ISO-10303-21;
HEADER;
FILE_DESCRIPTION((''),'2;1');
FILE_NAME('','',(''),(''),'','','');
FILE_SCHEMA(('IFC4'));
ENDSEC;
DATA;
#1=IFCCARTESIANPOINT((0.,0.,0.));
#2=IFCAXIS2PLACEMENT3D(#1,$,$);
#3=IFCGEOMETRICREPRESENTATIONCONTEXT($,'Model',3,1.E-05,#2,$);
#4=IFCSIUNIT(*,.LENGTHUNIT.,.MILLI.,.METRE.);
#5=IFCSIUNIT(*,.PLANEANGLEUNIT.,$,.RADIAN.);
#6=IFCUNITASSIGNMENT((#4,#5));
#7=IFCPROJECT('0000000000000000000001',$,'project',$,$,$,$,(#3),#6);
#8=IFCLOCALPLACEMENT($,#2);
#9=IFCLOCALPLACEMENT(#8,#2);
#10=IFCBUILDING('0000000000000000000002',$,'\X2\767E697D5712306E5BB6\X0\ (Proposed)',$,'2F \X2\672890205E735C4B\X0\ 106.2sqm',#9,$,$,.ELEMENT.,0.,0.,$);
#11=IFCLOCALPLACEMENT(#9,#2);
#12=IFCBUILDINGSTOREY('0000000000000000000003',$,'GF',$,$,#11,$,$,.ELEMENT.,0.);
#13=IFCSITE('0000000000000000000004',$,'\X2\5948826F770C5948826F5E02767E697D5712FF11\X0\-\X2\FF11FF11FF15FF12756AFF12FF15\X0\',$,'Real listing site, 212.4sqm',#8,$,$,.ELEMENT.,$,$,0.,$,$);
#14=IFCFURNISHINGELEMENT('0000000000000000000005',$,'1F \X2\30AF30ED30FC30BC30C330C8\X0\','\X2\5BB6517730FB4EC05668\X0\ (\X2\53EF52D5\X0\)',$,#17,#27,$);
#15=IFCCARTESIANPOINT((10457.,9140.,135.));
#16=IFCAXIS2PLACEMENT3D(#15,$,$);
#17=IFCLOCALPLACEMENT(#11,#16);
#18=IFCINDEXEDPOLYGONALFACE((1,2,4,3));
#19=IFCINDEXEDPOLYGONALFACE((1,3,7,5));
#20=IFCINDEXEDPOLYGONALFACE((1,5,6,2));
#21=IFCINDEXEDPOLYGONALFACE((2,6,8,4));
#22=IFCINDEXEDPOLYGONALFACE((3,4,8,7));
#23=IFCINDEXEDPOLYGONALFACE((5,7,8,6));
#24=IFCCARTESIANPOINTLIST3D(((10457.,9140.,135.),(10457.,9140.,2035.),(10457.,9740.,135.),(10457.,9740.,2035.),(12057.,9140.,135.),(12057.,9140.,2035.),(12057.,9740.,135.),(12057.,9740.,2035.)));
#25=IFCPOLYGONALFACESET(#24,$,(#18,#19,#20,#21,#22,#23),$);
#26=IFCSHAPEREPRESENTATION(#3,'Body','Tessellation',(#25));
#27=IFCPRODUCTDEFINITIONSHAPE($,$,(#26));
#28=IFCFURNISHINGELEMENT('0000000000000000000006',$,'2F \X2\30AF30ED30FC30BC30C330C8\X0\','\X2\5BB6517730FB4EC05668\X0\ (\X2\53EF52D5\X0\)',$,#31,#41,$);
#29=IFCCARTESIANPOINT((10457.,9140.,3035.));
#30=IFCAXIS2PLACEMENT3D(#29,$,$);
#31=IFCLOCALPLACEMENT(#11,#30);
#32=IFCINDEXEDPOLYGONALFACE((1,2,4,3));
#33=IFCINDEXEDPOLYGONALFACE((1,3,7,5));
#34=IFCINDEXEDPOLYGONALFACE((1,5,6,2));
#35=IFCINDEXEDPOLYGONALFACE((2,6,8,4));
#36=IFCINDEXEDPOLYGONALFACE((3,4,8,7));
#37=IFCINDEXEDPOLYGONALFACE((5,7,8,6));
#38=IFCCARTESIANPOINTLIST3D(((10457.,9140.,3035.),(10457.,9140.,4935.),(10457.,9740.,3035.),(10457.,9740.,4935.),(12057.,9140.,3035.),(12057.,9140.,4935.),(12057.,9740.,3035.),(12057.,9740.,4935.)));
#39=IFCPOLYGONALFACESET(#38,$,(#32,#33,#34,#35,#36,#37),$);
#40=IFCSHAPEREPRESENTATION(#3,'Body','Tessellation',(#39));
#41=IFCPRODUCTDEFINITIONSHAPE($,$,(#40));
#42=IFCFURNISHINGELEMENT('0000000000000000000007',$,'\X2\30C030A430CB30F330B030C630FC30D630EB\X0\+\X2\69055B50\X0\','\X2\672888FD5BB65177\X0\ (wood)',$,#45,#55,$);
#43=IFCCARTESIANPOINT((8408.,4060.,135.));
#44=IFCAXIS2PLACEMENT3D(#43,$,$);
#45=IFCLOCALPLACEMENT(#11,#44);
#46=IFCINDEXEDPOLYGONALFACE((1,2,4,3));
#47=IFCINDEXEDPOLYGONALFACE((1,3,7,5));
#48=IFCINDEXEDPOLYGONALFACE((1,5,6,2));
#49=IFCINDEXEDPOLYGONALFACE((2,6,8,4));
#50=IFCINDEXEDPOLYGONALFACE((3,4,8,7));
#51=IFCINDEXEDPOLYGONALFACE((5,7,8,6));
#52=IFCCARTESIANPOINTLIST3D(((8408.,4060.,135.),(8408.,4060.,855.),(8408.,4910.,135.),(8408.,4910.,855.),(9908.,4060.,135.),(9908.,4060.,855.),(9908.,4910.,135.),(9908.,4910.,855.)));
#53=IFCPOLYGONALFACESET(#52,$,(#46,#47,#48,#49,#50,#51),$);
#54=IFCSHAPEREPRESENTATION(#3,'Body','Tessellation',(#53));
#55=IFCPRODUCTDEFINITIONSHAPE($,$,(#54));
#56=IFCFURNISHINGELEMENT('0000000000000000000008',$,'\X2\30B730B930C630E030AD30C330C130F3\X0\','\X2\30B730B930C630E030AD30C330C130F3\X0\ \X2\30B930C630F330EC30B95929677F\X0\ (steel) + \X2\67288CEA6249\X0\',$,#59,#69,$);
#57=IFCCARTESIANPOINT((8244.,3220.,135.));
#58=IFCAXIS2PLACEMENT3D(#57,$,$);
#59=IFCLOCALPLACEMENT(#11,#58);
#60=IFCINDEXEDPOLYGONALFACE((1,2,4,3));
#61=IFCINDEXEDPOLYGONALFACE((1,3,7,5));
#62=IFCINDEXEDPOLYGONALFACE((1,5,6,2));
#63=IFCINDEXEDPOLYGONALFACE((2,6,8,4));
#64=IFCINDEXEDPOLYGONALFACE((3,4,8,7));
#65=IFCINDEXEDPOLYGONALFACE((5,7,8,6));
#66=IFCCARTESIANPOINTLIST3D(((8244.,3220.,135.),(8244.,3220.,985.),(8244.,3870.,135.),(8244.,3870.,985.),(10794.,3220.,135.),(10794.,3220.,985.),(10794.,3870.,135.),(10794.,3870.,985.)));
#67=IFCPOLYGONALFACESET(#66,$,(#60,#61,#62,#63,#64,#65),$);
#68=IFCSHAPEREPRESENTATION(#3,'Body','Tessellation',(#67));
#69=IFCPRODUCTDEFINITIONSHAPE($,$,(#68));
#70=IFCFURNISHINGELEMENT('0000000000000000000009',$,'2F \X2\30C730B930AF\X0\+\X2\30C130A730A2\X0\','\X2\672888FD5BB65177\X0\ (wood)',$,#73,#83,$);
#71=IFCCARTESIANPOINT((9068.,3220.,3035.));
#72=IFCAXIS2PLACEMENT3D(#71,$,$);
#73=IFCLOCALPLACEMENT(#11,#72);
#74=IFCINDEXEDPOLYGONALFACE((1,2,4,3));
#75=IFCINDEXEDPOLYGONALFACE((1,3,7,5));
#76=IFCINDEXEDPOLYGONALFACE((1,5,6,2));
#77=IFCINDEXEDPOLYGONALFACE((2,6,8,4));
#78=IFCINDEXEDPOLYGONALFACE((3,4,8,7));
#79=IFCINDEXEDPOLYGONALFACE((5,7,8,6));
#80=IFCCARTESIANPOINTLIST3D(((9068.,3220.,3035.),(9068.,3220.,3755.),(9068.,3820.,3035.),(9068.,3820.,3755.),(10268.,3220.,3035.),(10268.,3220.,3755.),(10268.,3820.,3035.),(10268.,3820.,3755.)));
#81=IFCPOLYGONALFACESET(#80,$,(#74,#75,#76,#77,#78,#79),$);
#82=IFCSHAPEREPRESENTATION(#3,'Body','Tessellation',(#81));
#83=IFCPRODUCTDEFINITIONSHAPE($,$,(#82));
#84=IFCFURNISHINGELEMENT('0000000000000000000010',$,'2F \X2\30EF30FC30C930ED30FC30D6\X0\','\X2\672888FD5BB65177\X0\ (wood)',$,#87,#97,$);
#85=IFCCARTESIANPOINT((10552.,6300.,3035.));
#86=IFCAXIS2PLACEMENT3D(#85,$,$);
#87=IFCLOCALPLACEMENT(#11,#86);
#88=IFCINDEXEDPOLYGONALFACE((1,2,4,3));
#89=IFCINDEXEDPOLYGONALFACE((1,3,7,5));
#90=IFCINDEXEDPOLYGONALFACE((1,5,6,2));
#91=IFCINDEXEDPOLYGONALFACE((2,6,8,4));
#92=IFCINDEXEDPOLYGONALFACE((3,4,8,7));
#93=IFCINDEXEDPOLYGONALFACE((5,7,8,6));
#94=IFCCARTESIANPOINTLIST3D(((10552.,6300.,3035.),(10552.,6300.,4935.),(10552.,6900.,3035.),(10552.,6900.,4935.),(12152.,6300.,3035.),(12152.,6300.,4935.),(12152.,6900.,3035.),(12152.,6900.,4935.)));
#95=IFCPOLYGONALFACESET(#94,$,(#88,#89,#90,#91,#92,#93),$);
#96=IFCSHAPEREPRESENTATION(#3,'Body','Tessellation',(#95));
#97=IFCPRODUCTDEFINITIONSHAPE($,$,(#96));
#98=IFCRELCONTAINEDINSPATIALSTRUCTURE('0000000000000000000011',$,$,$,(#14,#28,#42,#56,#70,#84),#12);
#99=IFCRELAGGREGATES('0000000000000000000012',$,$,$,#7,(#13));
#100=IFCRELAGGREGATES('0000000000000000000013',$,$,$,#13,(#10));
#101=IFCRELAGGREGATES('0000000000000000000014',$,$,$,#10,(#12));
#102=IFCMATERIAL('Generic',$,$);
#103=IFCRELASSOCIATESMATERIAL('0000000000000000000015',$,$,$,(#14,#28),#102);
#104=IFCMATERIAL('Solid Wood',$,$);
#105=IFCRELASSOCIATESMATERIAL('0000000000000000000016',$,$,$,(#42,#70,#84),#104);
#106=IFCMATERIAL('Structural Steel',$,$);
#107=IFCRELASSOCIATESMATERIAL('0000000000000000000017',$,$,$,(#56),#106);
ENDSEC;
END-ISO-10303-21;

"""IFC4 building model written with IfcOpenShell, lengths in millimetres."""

from ifc_helpers import new_model, si_unit, frame, frame_2d, origin, place, context, project, spatial, rectangle, extrude, material, element, save


model = new_model("IFC4")

# Units and contexts
model_context = context("Model", 3, precision=1e-05, world=origin())
ifc_project = project(units=[si_unit("LENGTHUNIT", "METRE", prefix="MILLI"), si_unit("PLANEANGLEUNIT", "RADIAN")], contexts=[model_context])

# Site, building, storey
site_placement = place(None, origin())
site = spatial("IfcSite", under=ifc_project, at=site_placement, Name="奈良県奈良市百楽園１-１１５２番２５", ObjectType="Real listing site, 212.4sqm", CompositionType="ELEMENT", RefElevation=0.0)
building_placement = place(site_placement, origin())
building = spatial("IfcBuilding", under=site, at=building_placement, Name="百楽園の家 (Proposed)", ObjectType="2F 木造平屋 106.2sqm", CompositionType="ELEMENT", ElevationOfRefHeight=0.0, ElevationOfTerrain=0.0)
storey_placement = place(building_placement, origin())
storey = spatial("IfcBuildingStorey", under=building, at=storey_placement, Name="GF", CompositionType="ELEMENT", Elevation=0.0)

# Shared definitions
ifc_material_1 = material(Name="Solid Wood")

# Shared definitions
ifc_material_2 = material(Name="Generic")

# Furnishing elements
furnishing_1_placement = place(storey_placement, frame((10457.0, 9140.0, 135.0)))
element("IfcFurnishingElement", 1, at=furnishing_1_placement, inside=storey, material=ifc_material_2, Name="1F クローゼット", Description="家具・什器 (可動)", context=model_context, shape_type="SweptSolid", body=[
    extrude(rectangle(XDim=1600.0, YDim=600.0, at=frame_2d((800.0, 300.0))), frame((10457.0, 9140.0, 135.0)), (0.0, 0.0, 1.0), 1900.0),
])
furnishing_2_placement = place(storey_placement, frame((10457.0, 9140.0, 3035.0)))
element("IfcFurnishingElement", 2, at=furnishing_2_placement, inside=storey, material=ifc_material_2, Name="2F クローゼット", Description="家具・什器 (可動)", context=model_context, shape_type="SweptSolid", body=[
    extrude(rectangle(XDim=1600.0, YDim=600.0, at=frame_2d((800.0, 300.0))), frame((10457.0, 9140.0, 3035.0)), (0.0, 0.0, 1.0), 1900.0),
])
furnishing_3_placement = place(storey_placement, frame((8408.0, 4060.0, 135.0)))
element("IfcFurnishingElement", 3, at=furnishing_3_placement, inside=storey, material=ifc_material_1, Name="ダイニングテーブル+椅子", Description="木製家具 (wood)", context=model_context, shape_type="SweptSolid", body=[
    extrude(rectangle(XDim=1500.0, YDim=850.0, at=frame_2d((750.0, 425.0))), frame((8408.0, 4060.0, 135.0)), (0.0, 0.0, 1.0), 720.0),
])
ifc_material_3 = material(Name="Structural Steel")
furnishing_4_placement = place(storey_placement, frame((8244.0, 3220.0, 135.0)))
element("IfcFurnishingElement", 4, at=furnishing_4_placement, inside=storey, material=ifc_material_3, Name="システムキッチン", Description="システムキッチン ステンレス天板 (steel) + 木質扉", context=model_context, shape_type="SweptSolid", body=[
    extrude(rectangle(XDim=2550.0, YDim=650.0, at=frame_2d((1275.0, 325.0))), frame((8244.0, 3220.0, 135.0)), (0.0, 0.0, 1.0), 850.0),
])
furnishing_5_placement = place(storey_placement, frame((9068.0, 3220.0, 3035.0)))
element("IfcFurnishingElement", 5, at=furnishing_5_placement, inside=storey, material=ifc_material_1, Name="2F デスク+チェア", Description="木製家具 (wood)", context=model_context, shape_type="SweptSolid", body=[
    extrude(rectangle(XDim=1200.0, YDim=600.0, at=frame_2d((600.0, 300.0))), frame((9068.0, 3220.0, 3035.0)), (0.0, 0.0, 1.0), 720.0),
])
furnishing_6_placement = place(storey_placement, frame((10552.0, 6300.0, 3035.0)))
element("IfcFurnishingElement", 6, at=furnishing_6_placement, inside=storey, material=ifc_material_1, Name="2F ワードローブ", Description="木製家具 (wood)", context=model_context, shape_type="SweptSolid", body=[
    extrude(rectangle(XDim=1600.0, YDim=600.0, at=frame_2d((800.0, 300.0))), frame((10552.0, 6300.0, 3035.0)), (0.0, 0.0, 1.0), 1900.0),
])

save(model, "model.ifc")
